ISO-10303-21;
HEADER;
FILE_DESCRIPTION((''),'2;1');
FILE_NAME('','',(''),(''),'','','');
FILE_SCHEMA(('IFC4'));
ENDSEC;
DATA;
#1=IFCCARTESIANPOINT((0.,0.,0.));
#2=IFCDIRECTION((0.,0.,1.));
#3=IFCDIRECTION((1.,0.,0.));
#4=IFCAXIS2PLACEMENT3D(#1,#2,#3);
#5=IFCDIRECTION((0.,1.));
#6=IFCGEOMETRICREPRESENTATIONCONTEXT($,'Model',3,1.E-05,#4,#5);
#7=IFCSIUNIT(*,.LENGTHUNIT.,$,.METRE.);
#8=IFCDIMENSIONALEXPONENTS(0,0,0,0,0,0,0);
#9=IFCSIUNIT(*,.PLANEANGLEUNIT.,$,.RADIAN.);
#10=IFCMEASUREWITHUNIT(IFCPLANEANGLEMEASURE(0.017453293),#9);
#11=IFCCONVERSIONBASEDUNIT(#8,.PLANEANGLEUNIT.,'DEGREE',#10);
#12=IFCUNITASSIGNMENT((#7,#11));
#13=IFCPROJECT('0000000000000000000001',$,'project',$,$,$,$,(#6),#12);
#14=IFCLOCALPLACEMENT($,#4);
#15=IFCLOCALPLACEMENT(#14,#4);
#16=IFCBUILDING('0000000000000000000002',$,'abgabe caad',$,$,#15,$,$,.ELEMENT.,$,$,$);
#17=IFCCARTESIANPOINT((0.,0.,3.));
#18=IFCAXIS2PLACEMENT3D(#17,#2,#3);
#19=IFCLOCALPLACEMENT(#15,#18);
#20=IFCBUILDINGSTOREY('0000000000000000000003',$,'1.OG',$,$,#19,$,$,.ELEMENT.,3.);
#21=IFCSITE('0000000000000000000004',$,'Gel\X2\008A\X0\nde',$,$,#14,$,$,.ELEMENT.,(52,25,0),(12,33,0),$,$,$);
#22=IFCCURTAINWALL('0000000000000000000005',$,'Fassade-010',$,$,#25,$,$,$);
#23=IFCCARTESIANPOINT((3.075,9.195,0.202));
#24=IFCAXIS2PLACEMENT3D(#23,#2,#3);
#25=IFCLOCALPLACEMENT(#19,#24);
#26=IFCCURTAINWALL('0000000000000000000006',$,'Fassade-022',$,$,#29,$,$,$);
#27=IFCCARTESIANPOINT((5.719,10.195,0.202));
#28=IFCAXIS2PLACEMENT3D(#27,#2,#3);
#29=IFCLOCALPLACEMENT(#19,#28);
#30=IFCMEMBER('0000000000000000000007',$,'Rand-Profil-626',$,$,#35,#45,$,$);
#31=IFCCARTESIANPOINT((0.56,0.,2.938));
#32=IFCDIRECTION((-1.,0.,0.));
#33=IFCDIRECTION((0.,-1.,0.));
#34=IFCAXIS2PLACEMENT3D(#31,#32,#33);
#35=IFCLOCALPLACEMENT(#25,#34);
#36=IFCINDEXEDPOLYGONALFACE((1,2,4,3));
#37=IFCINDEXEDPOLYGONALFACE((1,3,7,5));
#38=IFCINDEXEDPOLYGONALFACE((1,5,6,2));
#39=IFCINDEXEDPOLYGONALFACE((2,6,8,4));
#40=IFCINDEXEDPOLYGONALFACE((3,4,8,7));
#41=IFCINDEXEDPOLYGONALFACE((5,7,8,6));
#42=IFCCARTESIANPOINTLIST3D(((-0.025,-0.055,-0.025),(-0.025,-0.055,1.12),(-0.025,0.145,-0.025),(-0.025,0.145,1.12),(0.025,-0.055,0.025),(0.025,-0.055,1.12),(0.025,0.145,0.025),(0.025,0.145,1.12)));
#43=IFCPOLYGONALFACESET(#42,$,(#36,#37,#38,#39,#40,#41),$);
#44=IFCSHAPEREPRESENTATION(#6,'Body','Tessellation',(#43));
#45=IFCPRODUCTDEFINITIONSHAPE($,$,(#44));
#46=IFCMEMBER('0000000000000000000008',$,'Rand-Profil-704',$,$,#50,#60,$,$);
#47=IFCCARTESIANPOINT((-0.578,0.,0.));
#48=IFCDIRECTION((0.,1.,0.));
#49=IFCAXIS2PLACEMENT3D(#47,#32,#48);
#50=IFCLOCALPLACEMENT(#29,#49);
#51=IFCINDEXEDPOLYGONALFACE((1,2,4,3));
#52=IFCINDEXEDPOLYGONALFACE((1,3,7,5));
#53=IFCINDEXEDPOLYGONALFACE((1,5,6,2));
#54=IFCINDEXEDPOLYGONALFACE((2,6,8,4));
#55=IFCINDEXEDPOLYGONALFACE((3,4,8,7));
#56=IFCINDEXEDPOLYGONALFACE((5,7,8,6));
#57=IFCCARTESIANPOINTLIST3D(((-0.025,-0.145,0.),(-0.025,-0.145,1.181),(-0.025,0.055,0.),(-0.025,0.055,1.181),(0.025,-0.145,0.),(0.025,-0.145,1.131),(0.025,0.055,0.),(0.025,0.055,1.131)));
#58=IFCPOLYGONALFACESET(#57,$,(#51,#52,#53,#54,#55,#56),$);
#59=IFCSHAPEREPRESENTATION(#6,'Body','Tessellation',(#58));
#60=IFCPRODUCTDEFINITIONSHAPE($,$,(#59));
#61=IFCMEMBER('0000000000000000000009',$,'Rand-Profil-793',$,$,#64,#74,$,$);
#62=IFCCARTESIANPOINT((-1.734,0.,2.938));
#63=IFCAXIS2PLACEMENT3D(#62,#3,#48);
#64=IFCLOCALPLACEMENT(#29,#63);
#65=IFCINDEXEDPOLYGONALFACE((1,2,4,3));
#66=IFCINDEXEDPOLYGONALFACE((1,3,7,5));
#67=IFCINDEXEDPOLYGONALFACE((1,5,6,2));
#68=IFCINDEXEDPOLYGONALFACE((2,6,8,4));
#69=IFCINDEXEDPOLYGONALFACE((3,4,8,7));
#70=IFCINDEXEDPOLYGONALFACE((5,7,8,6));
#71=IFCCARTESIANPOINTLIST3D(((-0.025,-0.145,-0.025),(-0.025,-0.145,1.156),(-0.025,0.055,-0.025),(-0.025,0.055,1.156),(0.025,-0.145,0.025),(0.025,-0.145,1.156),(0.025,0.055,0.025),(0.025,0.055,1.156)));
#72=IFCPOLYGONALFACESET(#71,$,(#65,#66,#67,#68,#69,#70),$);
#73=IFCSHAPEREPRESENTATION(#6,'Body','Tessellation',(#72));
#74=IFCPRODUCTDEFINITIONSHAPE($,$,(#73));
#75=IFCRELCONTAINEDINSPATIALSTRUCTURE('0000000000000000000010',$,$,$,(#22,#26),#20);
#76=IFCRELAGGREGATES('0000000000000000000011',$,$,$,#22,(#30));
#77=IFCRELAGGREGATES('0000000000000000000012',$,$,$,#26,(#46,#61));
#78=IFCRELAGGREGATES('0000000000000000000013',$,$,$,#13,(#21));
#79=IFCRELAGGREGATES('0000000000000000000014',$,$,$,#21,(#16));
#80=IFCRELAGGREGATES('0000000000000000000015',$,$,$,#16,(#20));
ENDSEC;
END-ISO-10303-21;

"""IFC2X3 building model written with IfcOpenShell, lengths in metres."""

from ifc_helpers import new_model, entity, si_unit, converted_unit, direction, frame, origin_with_axes, place, context, project, spatial, polyline, outline, extrude, clip, halfspace, element, aggregate, save


model = new_model("IFC2X3")

# Units and contexts
model_context = context("Model", 3, precision=1e-05, world=origin_with_axes(), true_north=direction((0.0, 1.0)))
ifc_project = project(units=[si_unit("LENGTHUNIT", "METRE"), converted_unit("PLANEANGLEUNIT", "DEGREE", entity("IfcPlaneAngleMeasure", 0.017453293), si_unit("PLANEANGLEUNIT", "RADIAN"), dimensions=[0, 0, 0, 0, 0, 0, 0])], contexts=[model_context])

# Site, building, storey
site_placement = place(None, origin_with_axes())
site = spatial("IfcSite", under=ifc_project, at=site_placement, Name="Gel\u008ande", CompositionType="ELEMENT", RefLatitude=(52, 25, 0), RefLongitude=(12, 33, 0))
building_placement = place(site_placement, origin_with_axes())
building = spatial("IfcBuilding", under=site, at=building_placement, Name="abgabe caad", CompositionType="ELEMENT")
storey_placement = place(building_placement, frame((0.0, 0.0, 3.0), z_axis=(0.0, 0.0, 1.0), x_axis=(1.0, 0.0, 0.0)))
storey = spatial("IfcBuildingStorey", under=building, at=storey_placement, Name="1.OG", CompositionType="ELEMENT", Elevation=3.0)

# Curtain wall
curtain_wall_1_placement = place(storey_placement, frame((3.075, 9.195, 0.202), z_axis=(0.0, 0.0, 1.0), x_axis=(1.0, 0.0, 0.0)))
curtain_wall_1 = element("IfcCurtainWall", 1, at=curtain_wall_1_placement, inside=storey, Name="Fassade-010")

# Curtain wall
curtain_wall_2_placement = place(storey_placement, frame((5.719, 10.195, 0.202), z_axis=(0.0, 0.0, 1.0), x_axis=(1.0, 0.0, 0.0)))
curtain_wall_2 = element("IfcCurtainWall", 2, at=curtain_wall_2_placement, inside=storey, Name="Fassade-022")

# Members
member_1_placement = place(curtain_wall_1_placement, frame((0.56, 0.0, 2.938), z_axis=(-1.0, 0.0, 0.0), x_axis=(0.0, -1.0, 0.0)))
member_1 = element("IfcMember", 3, at=member_1_placement, Name="Rand-Profil-626", context=model_context, shape_type="Clipping", body=[
    clip(extrude(outline(polyline([(-0.025, -0.145), (0.025, -0.145), (0.025, 0.055), (-0.025, 0.055), (-0.025, -0.145)])), frame((0.0, 0.0, -0.025), z_axis=(0.0, 0.0, 1.0), x_axis=(-1.0, 0.0, 0.0)), (0.0, 0.0, 1.0), 1.145), halfspace(frame((0.0, 0.0, 0.0), z_axis=(-0.707107, 0.0, 0.707107), x_axis=(-0.707107, 0.0, -0.707107)), True)),
])
member_2_placement = place(curtain_wall_2_placement, frame((-0.578, 0.0, 0.0), z_axis=(-1.0, 0.0, 0.0), x_axis=(0.0, 1.0, 0.0)))
member_2 = element("IfcMember", 4, at=member_2_placement, Name="Rand-Profil-704", context=model_context, shape_type="Clipping", body=[
    clip(extrude(outline(polyline([(0.025, -0.145), (0.025, 0.055), (-0.025, 0.055), (-0.025, -0.145), (0.025, -0.145)])), origin_with_axes(), (0.0, 0.0, 1.0), 1.181), halfspace(frame((0.578, 0.0, 0.578), z_axis=(-0.707107, 0.0, -0.707107), x_axis=(0.707107, 0.0, -0.707107)), True)),
])
member_3_placement = place(curtain_wall_2_placement, frame((-1.734, 0.0, 2.938), z_axis=(1.0, 0.0, 0.0), x_axis=(0.0, 1.0, 0.0)))
member_3 = element("IfcMember", 5, at=member_3_placement, Name="Rand-Profil-793", context=model_context, shape_type="Clipping", body=[
    clip(extrude(outline(polyline([(-0.025, 0.145), (-0.025, -0.055), (0.025, -0.055), (0.025, 0.145), (-0.025, 0.145)])), frame((0.0, 0.0, -0.025), z_axis=(0.0, 0.0, 1.0), x_axis=(-1.0, 0.0, 0.0)), (0.0, 0.0, 1.0), 1.181), halfspace(frame((0.0, 0.0, 0.0), z_axis=(-0.707107, 0.0, 0.707107), x_axis=(-0.707107, 0.0, -0.707107)), True)),
])

aggregate(curtain_wall_1, [member_1])
aggregate(curtain_wall_2, [member_2, member_3])

save(model, "model.ifc")
